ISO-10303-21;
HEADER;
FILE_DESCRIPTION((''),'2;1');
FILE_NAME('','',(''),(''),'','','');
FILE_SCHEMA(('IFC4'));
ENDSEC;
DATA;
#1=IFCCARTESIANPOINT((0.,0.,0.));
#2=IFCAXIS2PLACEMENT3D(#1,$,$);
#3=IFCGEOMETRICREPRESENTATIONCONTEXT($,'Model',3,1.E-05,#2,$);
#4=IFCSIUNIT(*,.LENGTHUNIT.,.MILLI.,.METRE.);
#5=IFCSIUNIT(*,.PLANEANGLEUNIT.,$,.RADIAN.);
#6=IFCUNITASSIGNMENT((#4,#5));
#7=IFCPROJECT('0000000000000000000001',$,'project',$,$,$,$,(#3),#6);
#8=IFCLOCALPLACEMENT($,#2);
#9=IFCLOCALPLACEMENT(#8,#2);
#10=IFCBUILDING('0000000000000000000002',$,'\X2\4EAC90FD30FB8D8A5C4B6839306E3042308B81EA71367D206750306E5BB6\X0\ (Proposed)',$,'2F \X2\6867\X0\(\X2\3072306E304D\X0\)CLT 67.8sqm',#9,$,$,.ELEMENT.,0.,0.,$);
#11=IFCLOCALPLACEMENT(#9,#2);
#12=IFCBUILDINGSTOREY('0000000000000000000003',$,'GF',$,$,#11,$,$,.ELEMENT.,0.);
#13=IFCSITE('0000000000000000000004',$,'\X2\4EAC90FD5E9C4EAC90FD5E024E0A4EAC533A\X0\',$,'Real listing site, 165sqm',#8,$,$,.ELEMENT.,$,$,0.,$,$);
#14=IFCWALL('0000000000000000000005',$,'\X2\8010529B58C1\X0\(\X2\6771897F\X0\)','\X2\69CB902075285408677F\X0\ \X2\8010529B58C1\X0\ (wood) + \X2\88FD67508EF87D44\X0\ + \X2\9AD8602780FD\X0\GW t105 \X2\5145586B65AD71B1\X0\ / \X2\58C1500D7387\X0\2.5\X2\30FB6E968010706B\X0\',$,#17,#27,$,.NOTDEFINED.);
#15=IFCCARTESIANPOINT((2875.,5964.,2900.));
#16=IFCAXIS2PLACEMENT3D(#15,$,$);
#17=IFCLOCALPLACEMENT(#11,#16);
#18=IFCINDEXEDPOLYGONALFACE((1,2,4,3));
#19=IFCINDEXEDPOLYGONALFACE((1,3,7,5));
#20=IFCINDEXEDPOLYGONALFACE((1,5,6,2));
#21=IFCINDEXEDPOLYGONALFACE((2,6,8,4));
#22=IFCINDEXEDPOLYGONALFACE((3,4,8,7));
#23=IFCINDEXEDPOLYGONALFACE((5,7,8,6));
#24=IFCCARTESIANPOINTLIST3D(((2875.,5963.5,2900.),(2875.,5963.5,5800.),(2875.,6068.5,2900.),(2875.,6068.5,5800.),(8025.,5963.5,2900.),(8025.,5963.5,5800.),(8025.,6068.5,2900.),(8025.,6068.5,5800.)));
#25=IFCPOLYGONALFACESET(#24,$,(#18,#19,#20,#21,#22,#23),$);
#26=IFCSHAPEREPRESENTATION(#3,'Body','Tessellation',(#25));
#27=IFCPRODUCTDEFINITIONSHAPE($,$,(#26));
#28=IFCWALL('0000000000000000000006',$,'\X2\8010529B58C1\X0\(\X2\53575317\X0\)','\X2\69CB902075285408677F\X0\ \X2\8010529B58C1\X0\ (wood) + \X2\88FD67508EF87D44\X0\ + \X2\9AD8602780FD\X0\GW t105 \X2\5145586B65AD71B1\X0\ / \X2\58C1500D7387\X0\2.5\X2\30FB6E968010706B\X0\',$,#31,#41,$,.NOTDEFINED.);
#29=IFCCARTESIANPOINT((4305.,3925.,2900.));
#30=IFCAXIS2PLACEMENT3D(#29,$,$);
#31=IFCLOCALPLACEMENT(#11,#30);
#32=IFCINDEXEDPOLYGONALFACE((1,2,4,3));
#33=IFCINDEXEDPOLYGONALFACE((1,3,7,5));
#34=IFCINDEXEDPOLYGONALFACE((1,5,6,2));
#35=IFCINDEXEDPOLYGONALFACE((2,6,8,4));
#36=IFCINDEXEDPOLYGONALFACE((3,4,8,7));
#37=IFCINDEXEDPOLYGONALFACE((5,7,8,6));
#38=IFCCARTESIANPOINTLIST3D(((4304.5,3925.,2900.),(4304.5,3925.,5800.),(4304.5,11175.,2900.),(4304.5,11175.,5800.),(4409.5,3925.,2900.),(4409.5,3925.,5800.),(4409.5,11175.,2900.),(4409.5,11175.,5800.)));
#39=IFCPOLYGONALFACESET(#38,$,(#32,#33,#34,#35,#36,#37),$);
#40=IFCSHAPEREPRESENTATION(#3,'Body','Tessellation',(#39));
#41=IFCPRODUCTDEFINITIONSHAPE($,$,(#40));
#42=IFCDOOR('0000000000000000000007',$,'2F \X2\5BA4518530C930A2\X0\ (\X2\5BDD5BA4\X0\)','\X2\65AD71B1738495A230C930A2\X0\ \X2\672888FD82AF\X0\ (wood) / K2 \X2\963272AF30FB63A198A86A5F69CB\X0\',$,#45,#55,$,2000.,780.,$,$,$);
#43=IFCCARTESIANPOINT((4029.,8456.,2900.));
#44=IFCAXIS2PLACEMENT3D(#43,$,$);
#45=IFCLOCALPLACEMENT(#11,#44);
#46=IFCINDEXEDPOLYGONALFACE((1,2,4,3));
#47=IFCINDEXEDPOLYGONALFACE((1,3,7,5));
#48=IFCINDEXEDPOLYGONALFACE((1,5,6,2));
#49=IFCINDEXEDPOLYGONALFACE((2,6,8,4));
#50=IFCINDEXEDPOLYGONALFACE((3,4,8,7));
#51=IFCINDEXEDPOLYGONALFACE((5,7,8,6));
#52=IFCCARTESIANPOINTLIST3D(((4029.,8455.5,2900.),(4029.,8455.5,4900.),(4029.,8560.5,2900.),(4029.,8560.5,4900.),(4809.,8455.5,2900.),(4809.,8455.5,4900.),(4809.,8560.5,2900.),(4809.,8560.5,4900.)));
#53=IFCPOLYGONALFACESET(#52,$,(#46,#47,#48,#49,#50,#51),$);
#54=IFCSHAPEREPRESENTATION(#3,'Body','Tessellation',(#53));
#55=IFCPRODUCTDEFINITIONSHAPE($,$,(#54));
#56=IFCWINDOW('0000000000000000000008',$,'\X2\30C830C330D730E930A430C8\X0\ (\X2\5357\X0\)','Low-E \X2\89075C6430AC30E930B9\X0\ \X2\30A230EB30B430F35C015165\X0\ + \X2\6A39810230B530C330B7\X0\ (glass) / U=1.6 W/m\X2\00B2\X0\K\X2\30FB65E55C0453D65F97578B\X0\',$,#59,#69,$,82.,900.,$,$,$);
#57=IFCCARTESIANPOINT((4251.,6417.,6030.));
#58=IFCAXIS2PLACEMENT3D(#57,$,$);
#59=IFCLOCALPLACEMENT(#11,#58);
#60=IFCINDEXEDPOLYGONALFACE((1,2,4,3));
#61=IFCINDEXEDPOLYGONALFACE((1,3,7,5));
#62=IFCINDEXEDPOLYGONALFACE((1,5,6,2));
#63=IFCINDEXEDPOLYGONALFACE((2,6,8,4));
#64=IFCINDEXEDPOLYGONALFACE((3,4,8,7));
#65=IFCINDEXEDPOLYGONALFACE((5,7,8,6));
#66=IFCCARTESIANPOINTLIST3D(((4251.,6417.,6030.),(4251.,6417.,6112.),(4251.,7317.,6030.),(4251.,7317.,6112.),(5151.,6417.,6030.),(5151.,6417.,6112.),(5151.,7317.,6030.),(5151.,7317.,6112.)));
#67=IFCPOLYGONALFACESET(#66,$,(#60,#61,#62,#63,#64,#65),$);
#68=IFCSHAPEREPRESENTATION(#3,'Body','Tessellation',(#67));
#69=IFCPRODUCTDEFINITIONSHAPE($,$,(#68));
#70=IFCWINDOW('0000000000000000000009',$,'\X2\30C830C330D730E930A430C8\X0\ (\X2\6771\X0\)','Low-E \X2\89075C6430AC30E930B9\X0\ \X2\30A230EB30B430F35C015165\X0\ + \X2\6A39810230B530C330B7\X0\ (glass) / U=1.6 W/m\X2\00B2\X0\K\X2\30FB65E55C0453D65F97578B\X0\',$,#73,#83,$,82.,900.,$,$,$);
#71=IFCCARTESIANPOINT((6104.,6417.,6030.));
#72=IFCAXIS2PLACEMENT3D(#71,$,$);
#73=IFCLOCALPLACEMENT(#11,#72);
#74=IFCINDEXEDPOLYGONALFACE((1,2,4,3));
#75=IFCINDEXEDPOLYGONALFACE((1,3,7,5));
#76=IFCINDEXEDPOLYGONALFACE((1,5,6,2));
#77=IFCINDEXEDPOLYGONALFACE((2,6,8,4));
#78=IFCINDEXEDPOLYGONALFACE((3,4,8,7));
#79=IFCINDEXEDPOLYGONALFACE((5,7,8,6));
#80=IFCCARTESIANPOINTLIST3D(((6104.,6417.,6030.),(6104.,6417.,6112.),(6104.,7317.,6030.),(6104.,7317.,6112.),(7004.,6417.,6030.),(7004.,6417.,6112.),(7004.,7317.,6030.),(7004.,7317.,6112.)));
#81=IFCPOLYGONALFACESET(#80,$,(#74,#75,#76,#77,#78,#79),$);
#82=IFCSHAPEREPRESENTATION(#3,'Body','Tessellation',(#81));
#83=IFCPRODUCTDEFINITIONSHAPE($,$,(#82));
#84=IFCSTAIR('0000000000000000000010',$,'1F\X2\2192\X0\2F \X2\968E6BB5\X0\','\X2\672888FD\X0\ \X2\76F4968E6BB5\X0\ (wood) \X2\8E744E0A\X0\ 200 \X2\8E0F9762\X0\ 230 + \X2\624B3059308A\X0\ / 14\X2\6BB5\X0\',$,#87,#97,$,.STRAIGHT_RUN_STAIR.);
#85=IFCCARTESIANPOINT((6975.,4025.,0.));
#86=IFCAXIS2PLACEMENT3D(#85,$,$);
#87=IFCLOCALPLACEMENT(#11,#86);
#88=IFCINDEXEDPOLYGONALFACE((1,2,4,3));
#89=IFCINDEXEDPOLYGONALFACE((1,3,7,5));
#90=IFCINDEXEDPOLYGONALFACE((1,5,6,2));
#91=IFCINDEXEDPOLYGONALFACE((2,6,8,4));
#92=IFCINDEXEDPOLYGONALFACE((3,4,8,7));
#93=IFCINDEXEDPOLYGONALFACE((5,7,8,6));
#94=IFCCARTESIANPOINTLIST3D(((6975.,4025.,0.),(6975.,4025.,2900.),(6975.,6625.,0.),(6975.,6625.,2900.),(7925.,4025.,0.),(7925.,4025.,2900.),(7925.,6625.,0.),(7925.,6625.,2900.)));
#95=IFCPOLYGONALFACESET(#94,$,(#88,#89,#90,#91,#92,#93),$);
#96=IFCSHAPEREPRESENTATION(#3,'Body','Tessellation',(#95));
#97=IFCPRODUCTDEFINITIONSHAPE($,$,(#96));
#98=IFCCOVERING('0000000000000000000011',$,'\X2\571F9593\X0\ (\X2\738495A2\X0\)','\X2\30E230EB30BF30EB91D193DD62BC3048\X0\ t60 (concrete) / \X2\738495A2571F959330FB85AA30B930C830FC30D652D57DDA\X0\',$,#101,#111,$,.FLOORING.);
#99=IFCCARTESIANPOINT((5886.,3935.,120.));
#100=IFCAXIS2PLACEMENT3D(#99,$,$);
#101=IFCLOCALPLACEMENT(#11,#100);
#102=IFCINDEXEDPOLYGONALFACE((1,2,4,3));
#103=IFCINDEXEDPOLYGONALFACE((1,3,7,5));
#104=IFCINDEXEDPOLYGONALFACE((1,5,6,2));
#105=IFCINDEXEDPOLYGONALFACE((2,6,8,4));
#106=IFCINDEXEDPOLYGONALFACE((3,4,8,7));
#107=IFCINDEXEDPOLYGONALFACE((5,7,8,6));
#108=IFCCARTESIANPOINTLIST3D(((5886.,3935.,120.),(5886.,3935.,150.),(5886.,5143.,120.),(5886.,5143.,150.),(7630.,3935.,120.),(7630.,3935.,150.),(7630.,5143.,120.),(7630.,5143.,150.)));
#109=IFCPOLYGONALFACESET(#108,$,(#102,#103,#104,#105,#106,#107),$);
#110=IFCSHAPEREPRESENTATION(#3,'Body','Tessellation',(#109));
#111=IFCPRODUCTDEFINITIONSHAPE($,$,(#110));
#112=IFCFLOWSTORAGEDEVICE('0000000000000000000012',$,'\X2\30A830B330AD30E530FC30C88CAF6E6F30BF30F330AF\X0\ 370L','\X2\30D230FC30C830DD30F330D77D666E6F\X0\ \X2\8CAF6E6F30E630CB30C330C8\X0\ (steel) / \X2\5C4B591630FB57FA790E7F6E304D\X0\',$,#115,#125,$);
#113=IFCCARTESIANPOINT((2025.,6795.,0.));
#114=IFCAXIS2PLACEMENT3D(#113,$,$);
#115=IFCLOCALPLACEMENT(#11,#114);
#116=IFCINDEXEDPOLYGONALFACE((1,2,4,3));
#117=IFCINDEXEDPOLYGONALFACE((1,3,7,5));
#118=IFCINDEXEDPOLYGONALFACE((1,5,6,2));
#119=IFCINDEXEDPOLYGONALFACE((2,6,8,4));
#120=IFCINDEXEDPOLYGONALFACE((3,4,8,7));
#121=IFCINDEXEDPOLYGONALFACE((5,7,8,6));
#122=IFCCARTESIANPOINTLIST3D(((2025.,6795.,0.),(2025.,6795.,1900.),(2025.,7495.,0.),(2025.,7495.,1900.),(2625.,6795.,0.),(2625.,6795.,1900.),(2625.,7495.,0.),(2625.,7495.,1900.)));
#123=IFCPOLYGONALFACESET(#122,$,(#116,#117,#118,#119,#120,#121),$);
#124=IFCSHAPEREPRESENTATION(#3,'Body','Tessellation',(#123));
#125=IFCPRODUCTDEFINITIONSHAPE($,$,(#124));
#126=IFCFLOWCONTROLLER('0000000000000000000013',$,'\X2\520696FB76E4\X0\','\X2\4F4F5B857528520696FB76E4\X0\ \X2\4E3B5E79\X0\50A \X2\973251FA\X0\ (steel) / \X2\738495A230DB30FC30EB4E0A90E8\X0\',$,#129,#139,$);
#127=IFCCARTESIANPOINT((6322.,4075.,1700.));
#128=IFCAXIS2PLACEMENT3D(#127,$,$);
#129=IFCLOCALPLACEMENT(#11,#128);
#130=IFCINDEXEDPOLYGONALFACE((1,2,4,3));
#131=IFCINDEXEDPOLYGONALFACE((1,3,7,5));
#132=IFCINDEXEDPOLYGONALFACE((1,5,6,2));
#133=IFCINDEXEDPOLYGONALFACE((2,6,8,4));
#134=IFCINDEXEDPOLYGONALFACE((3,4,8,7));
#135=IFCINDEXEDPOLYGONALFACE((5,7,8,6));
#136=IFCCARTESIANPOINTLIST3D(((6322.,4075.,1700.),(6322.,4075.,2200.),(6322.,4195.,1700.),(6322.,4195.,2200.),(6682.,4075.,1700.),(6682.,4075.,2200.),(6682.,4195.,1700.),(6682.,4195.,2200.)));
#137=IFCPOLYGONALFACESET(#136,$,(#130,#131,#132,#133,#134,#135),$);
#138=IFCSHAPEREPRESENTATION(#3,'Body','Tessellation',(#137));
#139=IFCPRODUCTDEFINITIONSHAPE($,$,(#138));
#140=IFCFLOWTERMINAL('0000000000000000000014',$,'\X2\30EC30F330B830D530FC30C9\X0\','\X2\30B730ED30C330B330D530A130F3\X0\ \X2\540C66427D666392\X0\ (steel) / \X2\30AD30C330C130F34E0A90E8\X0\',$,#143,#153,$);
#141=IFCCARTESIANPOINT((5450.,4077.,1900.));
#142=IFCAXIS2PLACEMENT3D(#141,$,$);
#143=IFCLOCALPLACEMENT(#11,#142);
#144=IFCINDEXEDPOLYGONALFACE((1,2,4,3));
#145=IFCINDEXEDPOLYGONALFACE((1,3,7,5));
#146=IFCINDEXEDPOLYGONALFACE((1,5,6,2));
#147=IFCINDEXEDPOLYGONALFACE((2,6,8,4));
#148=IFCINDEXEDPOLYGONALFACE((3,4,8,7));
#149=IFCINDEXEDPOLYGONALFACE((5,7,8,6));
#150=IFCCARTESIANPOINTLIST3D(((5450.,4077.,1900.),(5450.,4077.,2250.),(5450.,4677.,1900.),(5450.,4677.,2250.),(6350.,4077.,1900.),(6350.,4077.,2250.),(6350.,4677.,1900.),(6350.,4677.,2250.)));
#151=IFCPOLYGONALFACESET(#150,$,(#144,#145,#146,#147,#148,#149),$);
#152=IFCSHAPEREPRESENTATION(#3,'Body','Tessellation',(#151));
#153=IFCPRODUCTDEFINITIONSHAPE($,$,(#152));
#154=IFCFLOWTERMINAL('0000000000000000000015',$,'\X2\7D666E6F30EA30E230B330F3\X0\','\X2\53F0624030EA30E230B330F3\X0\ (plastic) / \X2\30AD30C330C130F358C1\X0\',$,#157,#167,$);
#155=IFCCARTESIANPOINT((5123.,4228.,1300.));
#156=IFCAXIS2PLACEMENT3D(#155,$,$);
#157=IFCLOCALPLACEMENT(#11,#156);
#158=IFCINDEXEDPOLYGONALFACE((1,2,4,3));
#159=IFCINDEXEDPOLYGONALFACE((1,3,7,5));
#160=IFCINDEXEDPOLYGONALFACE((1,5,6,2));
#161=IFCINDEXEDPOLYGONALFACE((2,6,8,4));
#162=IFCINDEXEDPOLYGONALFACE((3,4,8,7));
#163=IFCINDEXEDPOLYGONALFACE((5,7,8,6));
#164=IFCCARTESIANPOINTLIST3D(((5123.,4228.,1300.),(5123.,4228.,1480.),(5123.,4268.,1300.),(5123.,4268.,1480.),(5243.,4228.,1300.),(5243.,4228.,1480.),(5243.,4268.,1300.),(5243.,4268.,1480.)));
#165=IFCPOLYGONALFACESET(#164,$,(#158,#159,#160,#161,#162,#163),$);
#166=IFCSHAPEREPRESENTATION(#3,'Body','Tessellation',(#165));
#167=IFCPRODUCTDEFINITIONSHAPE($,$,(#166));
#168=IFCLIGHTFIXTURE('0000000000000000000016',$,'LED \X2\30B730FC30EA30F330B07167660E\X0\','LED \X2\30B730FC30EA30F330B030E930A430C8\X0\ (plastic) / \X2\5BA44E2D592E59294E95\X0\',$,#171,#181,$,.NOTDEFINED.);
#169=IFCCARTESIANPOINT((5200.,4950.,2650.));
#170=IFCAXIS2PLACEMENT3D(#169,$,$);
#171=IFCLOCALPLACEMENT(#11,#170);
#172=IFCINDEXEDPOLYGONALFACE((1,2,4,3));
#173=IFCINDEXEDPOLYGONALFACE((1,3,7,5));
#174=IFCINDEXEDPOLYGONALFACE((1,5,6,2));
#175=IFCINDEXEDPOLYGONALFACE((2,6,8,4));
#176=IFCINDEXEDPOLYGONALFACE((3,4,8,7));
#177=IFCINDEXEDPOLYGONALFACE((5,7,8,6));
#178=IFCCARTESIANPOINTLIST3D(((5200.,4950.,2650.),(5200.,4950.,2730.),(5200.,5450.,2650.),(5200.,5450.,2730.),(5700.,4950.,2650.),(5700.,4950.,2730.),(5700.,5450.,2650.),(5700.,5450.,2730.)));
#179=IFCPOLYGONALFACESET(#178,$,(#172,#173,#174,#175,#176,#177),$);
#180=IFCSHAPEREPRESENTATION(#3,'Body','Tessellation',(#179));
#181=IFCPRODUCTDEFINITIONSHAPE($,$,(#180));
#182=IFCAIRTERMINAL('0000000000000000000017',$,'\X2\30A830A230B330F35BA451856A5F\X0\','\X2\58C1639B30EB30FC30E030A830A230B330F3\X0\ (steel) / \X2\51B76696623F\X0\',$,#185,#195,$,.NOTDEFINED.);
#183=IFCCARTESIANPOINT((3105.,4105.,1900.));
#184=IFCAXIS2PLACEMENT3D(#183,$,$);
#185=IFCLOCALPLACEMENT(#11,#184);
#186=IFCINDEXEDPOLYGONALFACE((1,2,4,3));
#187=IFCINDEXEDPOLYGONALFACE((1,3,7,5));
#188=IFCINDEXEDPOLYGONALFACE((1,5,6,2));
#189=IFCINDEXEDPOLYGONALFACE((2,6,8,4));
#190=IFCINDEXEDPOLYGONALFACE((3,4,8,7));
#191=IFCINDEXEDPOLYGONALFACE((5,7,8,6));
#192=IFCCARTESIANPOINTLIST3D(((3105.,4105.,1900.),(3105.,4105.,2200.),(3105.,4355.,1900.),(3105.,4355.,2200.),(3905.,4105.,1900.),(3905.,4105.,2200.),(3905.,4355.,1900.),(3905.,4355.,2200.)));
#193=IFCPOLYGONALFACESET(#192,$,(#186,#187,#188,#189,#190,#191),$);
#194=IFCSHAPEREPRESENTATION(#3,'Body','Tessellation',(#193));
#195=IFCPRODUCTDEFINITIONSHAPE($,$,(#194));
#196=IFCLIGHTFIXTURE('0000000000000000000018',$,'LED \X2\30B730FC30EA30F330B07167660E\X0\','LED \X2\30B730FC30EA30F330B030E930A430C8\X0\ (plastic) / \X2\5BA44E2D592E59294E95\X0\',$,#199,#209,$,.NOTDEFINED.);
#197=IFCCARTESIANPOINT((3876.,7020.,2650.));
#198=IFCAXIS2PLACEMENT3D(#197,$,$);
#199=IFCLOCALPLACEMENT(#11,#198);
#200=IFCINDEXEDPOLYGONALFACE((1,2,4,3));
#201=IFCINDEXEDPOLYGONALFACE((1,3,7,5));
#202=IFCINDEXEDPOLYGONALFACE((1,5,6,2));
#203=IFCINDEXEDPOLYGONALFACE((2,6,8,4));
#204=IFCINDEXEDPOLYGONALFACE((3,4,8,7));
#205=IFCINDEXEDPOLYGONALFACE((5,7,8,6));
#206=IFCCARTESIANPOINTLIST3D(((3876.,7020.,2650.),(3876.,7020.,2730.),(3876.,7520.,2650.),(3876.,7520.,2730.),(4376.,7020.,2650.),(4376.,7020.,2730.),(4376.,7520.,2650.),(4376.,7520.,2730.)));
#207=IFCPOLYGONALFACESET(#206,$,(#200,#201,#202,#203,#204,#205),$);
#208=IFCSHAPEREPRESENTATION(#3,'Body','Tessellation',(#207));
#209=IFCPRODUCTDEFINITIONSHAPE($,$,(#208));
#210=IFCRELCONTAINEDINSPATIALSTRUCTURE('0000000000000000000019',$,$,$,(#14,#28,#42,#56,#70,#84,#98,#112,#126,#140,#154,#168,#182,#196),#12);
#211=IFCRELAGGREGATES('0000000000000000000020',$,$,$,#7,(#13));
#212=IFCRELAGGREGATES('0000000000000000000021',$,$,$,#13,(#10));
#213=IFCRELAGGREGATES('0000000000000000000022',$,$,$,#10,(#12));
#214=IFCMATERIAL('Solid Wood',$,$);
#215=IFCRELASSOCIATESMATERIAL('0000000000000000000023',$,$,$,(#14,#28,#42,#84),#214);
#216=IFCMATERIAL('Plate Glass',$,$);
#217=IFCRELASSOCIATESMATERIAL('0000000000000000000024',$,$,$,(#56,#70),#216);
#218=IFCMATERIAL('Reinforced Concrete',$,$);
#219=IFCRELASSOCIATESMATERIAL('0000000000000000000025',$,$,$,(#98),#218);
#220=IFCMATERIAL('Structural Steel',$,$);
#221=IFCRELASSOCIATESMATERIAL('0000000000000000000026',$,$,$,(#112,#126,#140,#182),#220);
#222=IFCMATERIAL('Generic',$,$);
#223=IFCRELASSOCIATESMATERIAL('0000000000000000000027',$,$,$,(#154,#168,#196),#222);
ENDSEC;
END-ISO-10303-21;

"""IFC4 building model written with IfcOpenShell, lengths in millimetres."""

from ifc_helpers import new_model, si_unit, frame, frame_2d, origin, place, context, project, spatial, rectangle, extrude, material, element, fill, save


model = new_model("IFC4")

# Units and contexts
model_context = context("Model", 3, precision=1e-05, world=origin())
ifc_project = project(units=[si_unit("LENGTHUNIT", "METRE", prefix="MILLI"), si_unit("PLANEANGLEUNIT", "RADIAN")], contexts=[model_context])

# Site, building, storey
site_placement = place(None, origin())
site = spatial("IfcSite", under=ifc_project, at=site_placement, Name="京都府京都市上京区", ObjectType="Real listing site, 165sqm", CompositionType="ELEMENT", RefElevation=0.0)
building_placement = place(site_placement, origin())
building = spatial("IfcBuilding", under=site, at=building_placement, Name="京都・越屋根のある自然素材の家 (Proposed)", ObjectType="2F 桧(ひのき)CLT 67.8sqm", CompositionType="ELEMENT", ElevationOfRefHeight=0.0, ElevationOfTerrain=0.0)
storey_placement = place(building_placement, origin())
storey = spatial("IfcBuildingStorey", under=building, at=storey_placement, Name="GF", CompositionType="ELEMENT", Elevation=0.0)

# Shared definitions
ifc_material_1 = material(Name="Solid Wood")

# Wall
wall_1_placement = place(storey_placement, frame((2875.0, 5964.0, 2900.0)))
element("IfcWall", 1, at=wall_1_placement, inside=storey, material=ifc_material_1, Name="耐力壁(東西)", Description="構造用合板 耐力壁 (wood) + 製材軸組 + 高性能GW t105 充填断熱 / 壁倍率2.5・準耐火", PredefinedType="NOTDEFINED", context=model_context, shape_type="SweptSolid", body=[
    extrude(rectangle(XDim=5150.0, YDim=105.0, at=frame_2d((2575.0, 52.0))), frame((2875.0, 5964.0, 2900.0)), (0.0, 0.0, 1.0), 2900.0),
])

# Wall, opening, door
wall_2_placement = place(storey_placement, frame((4305.0, 3925.0, 2900.0)))
wall_2 = element("IfcWall", 2, at=wall_2_placement, inside=storey, material=ifc_material_1, Name="耐力壁(南北)", Description="構造用合板 耐力壁 (wood) + 製材軸組 + 高性能GW t105 充填断熱 / 壁倍率2.5・準耐火", PredefinedType="NOTDEFINED", context=model_context, shape_type="SweptSolid", body=[
    extrude(rectangle(XDim=105.0, YDim=7250.0, at=frame_2d((52.0, 3625.0))), frame((4305.0, 3925.0, 2900.0)), (0.0, 0.0, 1.0), 2900.0),
])
opening_placement = place(storey_placement, frame((4029.0, 8456.0, 2900.0)))
opening = element("IfcOpeningElement", 3, at=opening_placement, cuts=wall_2, PredefinedType="NOTDEFINED", context=model_context, shape_type="SweptSolid", body=[
    extrude(rectangle(XDim=780.0, YDim=105.0, at=frame_2d((390.0, 52.0))), frame((4029.0, 8456.0, 2900.0)), (0.0, 0.0, 1.0), 2000.0),
])
door_placement = place(storey_placement, frame((4029.0, 8456.0, 2900.0)))
door = element("IfcDoor", 4, at=door_placement, inside=storey, material=ifc_material_1, Name="2F 室内ドア (寝室)", Description="断熱玄関ドア 木製芯 (wood) / K2 防犯・採風機構", OverallHeight=2000.0, OverallWidth=780.0, context=model_context, shape_type="SweptSolid", body=[
    extrude(rectangle(XDim=780.0, YDim=105.0, at=frame_2d((390.0, 52.0))), frame((4029.0, 8456.0, 2900.0)), (0.0, 0.0, 1.0), 2000.0),
])
fill(opening, door)

# Windows
ifc_material_2 = material(Name="Plate Glass")
window_1_placement = place(storey_placement, frame((4251.0, 6417.0, 6030.0)))
element("IfcWindow", 5, at=window_1_placement, inside=storey, material=ifc_material_2, Name="トップライト (南)", Description="Low-E 複層ガラス アルゴン封入 + 樹脂サッシ (glass) / U=1.6 W/m²K・日射取得型", OverallHeight=82.0, OverallWidth=900.0, context=model_context, shape_type="SweptSolid", body=[
    extrude(rectangle(XDim=900.0, YDim=900.0, at=frame_2d((450.0, 450.0))), frame((4251.0, 6417.0, 6030.0)), (0.0, 0.0, 1.0), 82.0),
])
window_2_placement = place(storey_placement, frame((6104.0, 6417.0, 6030.0)))
element("IfcWindow", 6, at=window_2_placement, inside=storey, material=ifc_material_2, Name="トップライト (東)", Description="Low-E 複層ガラス アルゴン封入 + 樹脂サッシ (glass) / U=1.6 W/m²K・日射取得型", OverallHeight=82.0, OverallWidth=900.0, context=model_context, shape_type="SweptSolid", body=[
    extrude(rectangle(XDim=900.0, YDim=900.0, at=frame_2d((450.0, 450.0))), frame((6104.0, 6417.0, 6030.0)), (0.0, 0.0, 1.0), 82.0),
])

# Stair
stair_placement = place(storey_placement, frame((6975.0, 4025.0, 0.0)))
element("IfcStair", 7, at=stair_placement, inside=storey, material=ifc_material_1, Name="1F→2F 階段", Description="木製 直階段 (wood) 蹴上 200 踏面 230 + 手すり / 14段", PredefinedType="STRAIGHT_RUN_STAIR", context=model_context, shape_type="SweptSolid", body=[
    extrude(rectangle(XDim=950.0, YDim=2600.0, at=frame_2d((475.0, 1300.0))), frame((6975.0, 4025.0, 0.0)), (0.0, 0.0, 1.0), 2900.0),
])

# Covering
ifc_material_3 = material(Name="Reinforced Concrete")
covering_placement = place(storey_placement, frame((5886.0, 3935.0, 120.0)))
element("IfcCovering", 8, at=covering_placement, inside=storey, material=ifc_material_3, Name="土間 (玄関)", Description="モルタル金鏝押え t60 (concrete) / 玄関土間・薪ストーブ動線", PredefinedType="FLOORING", context=model_context, shape_type="SweptSolid", body=[
    extrude(rectangle(XDim=1744.0, YDim=1208.0, at=frame_2d((872.0, 604.0))), frame((5886.0, 3935.0, 120.0)), (0.0, 0.0, 1.0), 30.0),
])

# Flow storage device
ifc_material_4 = material(Name="Structural Steel")
flow_storage_device_placement = place(storey_placement, frame((2025.0, 6795.0, 0.0)))
element("IfcFlowStorageDevice", 9, at=flow_storage_device_placement, inside=storey, material=ifc_material_4, Name="エコキュート貯湯タンク 370L", Description="ヒートポンプ給湯 貯湯ユニット (steel) / 屋外・基礎置き", context=model_context, shape_type="SweptSolid", body=[
    extrude(rectangle(XDim=600.0, YDim=700.0, at=frame_2d((300.0, 350.0))), frame((2025.0, 6795.0, 0.0)), (0.0, 0.0, 1.0), 1900.0),
])

# Flow controller
flow_controller_placement = place(storey_placement, frame((6322.0, 4075.0, 1700.0)))
element("IfcFlowController", 10, at=flow_controller_placement, inside=storey, material=ifc_material_4, Name="分電盤", Description="住宅用分電盤 主幹50A 露出 (steel) / 玄関ホール上部", context=model_context, shape_type="SweptSolid", body=[
    extrude(rectangle(XDim=360.0, YDim=120.0, at=frame_2d((180.0, 60.0))), frame((6322.0, 4075.0, 1700.0)), (0.0, 0.0, 1.0), 500.0),
])

# Flow terminals
flow_terminal_1_placement = place(storey_placement, frame((5450.0, 4077.0, 1900.0)))
element("IfcFlowTerminal", 11, at=flow_terminal_1_placement, inside=storey, material=ifc_material_4, Name="レンジフード", Description="シロッコファン 同時給排 (steel) / キッチン上部", context=model_context, shape_type="SweptSolid", body=[
    extrude(rectangle(XDim=900.0, YDim=600.0, at=frame_2d((450.0, 300.0))), frame((5450.0, 4077.0, 1900.0)), (0.0, 0.0, 1.0), 350.0),
])
ifc_material_5 = material(Name="Generic")
flow_terminal_2_placement = place(storey_placement, frame((5123.0, 4228.0, 1300.0)))
element("IfcFlowTerminal", 12, at=flow_terminal_2_placement, inside=storey, material=ifc_material_5, Name="給湯リモコン", Description="台所リモコン (plastic) / キッチン壁", context=model_context, shape_type="SweptSolid", body=[
    extrude(rectangle(XDim=120.0, YDim=40.0, at=frame_2d((60.0, 20.0))), frame((5123.0, 4228.0, 1300.0)), (0.0, 0.0, 1.0), 180.0),
])

# Light fixture
light_fixture_1_placement = place(storey_placement, frame((5200.0, 4950.0, 2650.0)))
element("IfcLightFixture", 13, at=light_fixture_1_placement, inside=storey, material=ifc_material_5, Name="LED シーリング照明", Description="LED シーリングライト (plastic) / 室中央天井", PredefinedType="NOTDEFINED", context=model_context, shape_type="SweptSolid", body=[
    extrude(rectangle(XDim=500.0, YDim=500.0, at=frame_2d((250.0, 250.0))), frame((5200.0, 4950.0, 2650.0)), (0.0, 0.0, 1.0), 80.0),
])

# Air terminal
air_terminal_1_placement = place(storey_placement, frame((3105.0, 4105.0, 1900.0)))
element("IfcAirTerminal", 14, at=air_terminal_1_placement, inside=storey, material=ifc_material_4, Name="エアコン室内機", Description="壁掛ルームエアコン (steel) / 冷暖房", PredefinedType="NOTDEFINED", context=model_context, shape_type="SweptSolid", body=[
    extrude(rectangle(XDim=800.0, YDim=250.0, at=frame_2d((400.0, 125.0))), frame((3105.0, 4105.0, 1900.0)), (0.0, 0.0, 1.0), 300.0),
])

# Light fixture
light_fixture_2_placement = place(storey_placement, frame((3876.0, 7020.0, 2650.0)))
element("IfcLightFixture", 15, at=light_fixture_2_placement, inside=storey, material=ifc_material_5, Name="LED シーリング照明", Description="LED シーリングライト (plastic) / 室中央天井", PredefinedType="NOTDEFINED", context=model_context, shape_type="SweptSolid", body=[
    extrude(rectangle(XDim=500.0, YDim=500.0, at=frame_2d((250.0, 250.0))), frame((3876.0, 7020.0, 2650.0)), (0.0, 0.0, 1.0), 80.0),
])

save(model, "model.ifc")
